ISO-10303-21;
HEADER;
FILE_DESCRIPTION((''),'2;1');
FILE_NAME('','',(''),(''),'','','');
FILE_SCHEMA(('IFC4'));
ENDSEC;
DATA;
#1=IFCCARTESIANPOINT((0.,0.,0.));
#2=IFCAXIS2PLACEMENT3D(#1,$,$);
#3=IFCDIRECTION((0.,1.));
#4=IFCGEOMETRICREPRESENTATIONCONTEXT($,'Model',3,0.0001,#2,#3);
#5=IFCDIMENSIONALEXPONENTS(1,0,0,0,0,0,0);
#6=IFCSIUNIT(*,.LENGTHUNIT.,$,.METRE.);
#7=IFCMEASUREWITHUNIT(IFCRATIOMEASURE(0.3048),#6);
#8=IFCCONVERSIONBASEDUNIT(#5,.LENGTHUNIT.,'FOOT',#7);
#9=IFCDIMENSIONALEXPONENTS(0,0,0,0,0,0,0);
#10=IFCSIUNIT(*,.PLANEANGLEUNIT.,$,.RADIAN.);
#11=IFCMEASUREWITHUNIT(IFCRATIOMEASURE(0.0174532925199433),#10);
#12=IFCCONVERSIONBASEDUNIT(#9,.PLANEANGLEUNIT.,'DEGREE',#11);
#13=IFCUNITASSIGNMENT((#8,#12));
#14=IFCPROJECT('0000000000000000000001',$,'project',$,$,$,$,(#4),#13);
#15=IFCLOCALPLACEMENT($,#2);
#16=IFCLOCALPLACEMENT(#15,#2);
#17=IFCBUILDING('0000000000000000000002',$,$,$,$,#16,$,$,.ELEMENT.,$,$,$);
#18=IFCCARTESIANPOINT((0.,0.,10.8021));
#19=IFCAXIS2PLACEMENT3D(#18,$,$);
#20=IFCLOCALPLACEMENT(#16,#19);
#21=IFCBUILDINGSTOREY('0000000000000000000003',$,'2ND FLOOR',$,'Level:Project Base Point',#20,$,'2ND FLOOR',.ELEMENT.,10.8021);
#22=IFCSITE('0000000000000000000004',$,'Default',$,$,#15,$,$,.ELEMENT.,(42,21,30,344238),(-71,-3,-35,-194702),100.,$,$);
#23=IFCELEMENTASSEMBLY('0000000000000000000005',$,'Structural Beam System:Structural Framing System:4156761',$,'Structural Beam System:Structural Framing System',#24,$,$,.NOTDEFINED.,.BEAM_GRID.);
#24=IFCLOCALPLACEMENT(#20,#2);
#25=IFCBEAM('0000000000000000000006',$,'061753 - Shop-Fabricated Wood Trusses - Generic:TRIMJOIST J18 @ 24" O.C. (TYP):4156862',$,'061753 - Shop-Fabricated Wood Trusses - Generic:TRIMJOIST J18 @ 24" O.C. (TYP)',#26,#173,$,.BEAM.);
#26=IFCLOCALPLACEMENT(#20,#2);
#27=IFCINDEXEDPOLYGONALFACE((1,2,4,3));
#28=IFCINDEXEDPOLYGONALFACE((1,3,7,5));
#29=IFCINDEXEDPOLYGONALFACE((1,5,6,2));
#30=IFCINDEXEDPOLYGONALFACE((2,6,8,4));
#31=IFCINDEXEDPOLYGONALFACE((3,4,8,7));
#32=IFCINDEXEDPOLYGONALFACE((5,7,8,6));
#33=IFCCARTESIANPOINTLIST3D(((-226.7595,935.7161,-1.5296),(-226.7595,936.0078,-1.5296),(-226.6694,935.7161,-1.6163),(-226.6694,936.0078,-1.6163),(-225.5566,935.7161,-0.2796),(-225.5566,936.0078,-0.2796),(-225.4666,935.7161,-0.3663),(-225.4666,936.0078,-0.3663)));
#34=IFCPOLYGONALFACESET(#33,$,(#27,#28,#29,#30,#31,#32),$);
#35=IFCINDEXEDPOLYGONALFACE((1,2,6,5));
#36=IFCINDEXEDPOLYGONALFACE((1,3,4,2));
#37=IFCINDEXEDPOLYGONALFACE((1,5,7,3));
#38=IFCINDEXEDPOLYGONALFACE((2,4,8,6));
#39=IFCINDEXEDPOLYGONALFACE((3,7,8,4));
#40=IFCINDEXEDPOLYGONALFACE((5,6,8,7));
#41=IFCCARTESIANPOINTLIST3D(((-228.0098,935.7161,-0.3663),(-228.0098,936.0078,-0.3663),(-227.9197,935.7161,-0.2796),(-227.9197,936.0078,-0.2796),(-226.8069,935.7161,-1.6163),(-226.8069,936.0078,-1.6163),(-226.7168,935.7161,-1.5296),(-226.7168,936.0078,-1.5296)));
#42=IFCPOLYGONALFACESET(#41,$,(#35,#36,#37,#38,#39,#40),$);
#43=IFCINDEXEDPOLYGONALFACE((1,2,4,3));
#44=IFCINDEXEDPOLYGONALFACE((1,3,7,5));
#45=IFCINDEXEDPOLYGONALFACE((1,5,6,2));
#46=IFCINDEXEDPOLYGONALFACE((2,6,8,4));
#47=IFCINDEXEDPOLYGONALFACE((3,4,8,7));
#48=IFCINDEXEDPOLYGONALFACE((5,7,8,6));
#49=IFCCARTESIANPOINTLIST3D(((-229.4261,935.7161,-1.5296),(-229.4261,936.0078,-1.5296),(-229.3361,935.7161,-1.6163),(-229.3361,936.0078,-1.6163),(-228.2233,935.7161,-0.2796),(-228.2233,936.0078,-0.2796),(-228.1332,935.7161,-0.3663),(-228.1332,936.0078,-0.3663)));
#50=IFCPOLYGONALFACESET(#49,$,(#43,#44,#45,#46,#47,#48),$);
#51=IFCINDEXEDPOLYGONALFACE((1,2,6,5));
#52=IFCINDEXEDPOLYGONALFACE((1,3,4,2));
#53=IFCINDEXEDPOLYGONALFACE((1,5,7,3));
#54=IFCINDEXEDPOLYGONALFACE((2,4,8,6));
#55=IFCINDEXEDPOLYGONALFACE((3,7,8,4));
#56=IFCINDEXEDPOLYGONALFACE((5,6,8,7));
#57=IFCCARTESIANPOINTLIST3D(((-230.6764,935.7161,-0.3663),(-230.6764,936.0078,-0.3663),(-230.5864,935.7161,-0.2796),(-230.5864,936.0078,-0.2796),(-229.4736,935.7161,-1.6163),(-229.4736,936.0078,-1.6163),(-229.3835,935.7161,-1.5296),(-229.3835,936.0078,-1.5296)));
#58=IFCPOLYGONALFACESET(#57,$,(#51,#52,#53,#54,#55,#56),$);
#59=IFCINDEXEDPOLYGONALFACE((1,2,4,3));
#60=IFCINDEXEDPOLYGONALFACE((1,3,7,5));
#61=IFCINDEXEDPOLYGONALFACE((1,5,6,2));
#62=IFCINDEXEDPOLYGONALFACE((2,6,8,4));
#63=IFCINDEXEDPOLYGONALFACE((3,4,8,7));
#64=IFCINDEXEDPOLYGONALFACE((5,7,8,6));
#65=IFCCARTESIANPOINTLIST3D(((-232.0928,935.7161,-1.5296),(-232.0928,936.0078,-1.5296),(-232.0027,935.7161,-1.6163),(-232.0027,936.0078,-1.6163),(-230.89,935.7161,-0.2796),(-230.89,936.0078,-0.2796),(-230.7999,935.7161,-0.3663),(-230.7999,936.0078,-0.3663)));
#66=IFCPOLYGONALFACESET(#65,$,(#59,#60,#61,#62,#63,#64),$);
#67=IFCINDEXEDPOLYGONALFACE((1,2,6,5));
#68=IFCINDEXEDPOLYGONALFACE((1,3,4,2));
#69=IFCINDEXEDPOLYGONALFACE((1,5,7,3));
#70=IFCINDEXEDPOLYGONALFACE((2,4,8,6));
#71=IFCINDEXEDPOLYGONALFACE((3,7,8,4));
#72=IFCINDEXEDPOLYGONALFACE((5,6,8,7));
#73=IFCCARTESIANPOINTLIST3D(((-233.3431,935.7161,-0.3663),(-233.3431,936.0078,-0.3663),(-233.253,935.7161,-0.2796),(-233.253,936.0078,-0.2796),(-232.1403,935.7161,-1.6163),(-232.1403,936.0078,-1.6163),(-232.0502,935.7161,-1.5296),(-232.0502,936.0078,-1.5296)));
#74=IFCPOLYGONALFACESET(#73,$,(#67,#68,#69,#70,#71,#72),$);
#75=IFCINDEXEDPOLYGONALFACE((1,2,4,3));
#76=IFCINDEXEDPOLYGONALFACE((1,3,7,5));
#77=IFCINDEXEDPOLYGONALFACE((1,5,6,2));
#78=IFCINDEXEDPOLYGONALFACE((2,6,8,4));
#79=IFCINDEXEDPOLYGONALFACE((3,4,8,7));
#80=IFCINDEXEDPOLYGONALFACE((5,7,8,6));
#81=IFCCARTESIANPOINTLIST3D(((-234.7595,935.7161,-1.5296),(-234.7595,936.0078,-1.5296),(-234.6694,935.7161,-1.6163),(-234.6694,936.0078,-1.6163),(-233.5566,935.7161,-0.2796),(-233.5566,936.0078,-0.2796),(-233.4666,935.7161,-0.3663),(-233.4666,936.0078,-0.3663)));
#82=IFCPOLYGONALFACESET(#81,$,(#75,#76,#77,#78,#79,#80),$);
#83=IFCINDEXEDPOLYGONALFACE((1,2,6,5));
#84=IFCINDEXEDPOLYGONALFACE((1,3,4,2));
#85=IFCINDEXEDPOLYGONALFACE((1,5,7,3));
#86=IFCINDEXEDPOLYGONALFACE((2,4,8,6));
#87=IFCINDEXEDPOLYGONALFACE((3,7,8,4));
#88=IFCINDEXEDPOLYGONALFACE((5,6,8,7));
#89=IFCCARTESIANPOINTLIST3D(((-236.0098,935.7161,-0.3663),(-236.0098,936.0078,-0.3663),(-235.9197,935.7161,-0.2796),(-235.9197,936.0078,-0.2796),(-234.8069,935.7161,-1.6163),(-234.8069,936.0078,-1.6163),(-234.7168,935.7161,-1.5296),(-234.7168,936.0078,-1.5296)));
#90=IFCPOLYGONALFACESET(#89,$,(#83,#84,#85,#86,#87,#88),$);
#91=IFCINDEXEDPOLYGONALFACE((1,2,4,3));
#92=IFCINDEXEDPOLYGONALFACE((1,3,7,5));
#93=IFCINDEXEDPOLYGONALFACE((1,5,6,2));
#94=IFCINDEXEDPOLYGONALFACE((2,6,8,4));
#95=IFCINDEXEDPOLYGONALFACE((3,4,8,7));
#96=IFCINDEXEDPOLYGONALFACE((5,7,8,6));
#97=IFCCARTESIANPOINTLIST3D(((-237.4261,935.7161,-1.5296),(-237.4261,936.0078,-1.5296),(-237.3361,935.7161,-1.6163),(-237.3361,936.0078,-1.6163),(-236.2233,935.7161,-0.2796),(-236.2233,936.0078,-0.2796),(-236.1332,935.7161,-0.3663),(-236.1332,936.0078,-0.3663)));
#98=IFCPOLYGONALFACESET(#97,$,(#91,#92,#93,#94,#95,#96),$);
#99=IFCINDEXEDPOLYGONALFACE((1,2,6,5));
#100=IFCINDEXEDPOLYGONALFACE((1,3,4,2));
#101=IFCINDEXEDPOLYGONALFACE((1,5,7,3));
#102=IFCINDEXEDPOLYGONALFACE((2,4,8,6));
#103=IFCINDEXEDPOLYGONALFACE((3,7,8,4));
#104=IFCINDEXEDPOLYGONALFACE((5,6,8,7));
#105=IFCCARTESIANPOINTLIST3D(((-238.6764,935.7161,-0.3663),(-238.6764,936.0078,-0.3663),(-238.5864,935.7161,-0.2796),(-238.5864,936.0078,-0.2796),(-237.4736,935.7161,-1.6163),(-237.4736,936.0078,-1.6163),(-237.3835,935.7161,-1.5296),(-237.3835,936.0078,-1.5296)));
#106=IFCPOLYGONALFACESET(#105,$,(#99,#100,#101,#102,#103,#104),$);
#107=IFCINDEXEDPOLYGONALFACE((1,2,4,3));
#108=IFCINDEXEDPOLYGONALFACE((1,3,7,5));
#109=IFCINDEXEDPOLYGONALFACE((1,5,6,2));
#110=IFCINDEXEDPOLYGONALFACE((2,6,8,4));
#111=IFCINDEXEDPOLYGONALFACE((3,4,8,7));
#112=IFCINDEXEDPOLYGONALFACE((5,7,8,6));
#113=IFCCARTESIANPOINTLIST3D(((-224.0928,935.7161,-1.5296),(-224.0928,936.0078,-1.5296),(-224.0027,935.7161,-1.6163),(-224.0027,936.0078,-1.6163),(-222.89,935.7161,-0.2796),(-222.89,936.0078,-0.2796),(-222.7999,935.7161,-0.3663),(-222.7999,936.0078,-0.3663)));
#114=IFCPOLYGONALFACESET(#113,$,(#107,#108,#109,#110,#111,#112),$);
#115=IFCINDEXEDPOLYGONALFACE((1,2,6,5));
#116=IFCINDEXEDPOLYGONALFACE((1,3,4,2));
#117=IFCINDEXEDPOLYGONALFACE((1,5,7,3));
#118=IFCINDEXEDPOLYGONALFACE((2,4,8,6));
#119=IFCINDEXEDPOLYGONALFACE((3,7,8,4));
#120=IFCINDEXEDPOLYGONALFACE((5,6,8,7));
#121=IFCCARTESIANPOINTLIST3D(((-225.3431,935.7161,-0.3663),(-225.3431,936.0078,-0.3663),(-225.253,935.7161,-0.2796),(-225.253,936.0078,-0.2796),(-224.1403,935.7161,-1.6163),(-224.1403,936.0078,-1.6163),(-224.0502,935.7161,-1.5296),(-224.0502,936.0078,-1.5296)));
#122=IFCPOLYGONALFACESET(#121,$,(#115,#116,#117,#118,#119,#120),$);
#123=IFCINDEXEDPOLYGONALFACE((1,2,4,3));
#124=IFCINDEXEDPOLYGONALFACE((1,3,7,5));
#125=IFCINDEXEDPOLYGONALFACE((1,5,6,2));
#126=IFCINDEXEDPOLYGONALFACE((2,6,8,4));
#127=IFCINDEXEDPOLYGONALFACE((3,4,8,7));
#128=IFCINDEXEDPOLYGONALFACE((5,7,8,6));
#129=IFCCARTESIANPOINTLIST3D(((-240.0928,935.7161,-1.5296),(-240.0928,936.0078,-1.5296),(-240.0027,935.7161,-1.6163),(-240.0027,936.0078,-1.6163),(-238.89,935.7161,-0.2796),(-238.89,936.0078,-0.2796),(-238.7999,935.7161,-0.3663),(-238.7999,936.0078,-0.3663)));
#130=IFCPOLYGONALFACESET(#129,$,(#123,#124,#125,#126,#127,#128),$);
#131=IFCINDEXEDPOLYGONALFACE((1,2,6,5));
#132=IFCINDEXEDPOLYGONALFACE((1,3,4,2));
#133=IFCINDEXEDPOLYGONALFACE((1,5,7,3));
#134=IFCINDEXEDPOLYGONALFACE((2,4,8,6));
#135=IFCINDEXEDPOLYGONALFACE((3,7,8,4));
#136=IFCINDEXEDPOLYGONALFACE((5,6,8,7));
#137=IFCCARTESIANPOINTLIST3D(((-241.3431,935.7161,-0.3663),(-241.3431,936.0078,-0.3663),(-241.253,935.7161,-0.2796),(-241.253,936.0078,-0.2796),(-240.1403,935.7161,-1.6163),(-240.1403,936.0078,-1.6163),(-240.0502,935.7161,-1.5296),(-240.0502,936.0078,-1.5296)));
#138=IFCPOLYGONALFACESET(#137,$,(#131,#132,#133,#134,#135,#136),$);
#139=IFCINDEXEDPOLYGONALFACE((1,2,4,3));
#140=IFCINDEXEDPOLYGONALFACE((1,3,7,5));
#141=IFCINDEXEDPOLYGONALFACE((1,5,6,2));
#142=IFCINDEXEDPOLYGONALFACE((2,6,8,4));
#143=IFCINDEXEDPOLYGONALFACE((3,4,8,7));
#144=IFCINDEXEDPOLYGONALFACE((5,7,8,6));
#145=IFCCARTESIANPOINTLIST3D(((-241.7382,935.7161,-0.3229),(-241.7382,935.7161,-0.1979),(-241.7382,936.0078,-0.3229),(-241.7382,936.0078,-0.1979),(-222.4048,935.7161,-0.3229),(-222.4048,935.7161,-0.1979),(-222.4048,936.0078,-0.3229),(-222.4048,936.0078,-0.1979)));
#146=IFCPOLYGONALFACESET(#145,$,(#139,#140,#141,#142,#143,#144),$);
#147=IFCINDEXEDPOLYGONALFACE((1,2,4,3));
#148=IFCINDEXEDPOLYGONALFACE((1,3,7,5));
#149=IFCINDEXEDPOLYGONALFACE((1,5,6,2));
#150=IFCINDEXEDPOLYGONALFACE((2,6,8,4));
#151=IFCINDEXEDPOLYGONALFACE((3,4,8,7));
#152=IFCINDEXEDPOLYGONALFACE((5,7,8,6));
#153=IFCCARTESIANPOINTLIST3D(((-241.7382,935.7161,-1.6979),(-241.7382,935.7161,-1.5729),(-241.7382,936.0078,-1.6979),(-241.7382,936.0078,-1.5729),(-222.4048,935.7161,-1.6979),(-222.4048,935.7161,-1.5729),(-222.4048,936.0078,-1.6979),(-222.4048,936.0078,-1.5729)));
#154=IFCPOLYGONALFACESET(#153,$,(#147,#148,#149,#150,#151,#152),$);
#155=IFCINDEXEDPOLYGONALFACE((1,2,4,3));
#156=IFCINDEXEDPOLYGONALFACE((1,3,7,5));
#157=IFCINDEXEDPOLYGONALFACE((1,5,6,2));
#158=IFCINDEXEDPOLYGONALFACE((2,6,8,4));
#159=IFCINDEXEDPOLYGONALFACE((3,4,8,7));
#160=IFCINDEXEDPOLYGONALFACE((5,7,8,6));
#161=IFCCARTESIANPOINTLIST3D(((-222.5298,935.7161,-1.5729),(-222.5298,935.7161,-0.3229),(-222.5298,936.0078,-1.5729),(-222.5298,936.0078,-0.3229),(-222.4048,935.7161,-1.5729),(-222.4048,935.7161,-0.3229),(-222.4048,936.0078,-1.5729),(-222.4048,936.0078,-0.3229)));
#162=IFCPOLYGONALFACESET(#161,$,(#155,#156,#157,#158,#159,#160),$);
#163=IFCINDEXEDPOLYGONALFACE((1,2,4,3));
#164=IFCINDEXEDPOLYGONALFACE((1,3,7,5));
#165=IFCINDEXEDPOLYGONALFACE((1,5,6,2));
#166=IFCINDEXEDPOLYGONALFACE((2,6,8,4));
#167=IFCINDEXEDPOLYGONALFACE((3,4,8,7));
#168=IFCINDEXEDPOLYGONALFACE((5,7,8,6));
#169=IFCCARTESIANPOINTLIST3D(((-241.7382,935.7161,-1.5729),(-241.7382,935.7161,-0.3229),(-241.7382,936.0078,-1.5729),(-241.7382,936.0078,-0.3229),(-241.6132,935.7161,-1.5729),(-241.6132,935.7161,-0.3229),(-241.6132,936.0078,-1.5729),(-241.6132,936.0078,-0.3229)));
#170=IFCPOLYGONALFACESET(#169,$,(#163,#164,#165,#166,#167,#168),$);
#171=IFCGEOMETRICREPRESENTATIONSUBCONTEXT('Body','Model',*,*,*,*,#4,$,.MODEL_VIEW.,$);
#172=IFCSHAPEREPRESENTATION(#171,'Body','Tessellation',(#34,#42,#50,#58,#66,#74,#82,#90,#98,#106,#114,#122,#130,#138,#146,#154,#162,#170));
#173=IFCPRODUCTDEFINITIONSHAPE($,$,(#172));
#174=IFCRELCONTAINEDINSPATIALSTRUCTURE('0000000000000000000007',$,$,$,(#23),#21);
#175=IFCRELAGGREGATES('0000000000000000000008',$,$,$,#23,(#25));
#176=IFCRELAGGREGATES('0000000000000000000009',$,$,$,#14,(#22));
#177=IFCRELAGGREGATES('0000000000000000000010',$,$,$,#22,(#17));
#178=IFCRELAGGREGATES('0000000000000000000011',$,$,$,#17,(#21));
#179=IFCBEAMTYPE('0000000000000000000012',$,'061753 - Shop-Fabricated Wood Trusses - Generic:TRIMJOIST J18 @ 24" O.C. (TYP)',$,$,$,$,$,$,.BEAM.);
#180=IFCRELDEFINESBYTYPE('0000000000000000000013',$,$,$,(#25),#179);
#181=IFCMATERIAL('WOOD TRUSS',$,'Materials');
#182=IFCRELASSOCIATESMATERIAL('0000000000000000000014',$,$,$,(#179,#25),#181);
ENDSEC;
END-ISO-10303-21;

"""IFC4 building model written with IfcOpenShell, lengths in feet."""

from ifc_helpers import new_model, entity, si_unit, converted_unit, direction, frame, frame_2d, origin, origin_2d_with_axis, place, context, subcontext, project, spatial, rectangle, extrude, source, transform, mapped, material, material_profile, profile_set, profile_usage, type_object, type_shapes, element, aggregate, save


model = new_model("IFC4")

# Units and contexts
model_context = context("Model", 3, precision=0.0001, world=origin(), true_north=direction((0.0, 1.0)))
body_context = subcontext(model_context, "Body", "Model", "MODEL_VIEW")
ifc_project = project(units=[converted_unit("LENGTHUNIT", "FOOT", entity("IfcRatioMeasure", 0.3048), si_unit("LENGTHUNIT", "METRE"), dimensions=[1, 0, 0, 0, 0, 0, 0]), converted_unit("PLANEANGLEUNIT", "DEGREE", entity("IfcRatioMeasure", 0.0174532925199433), si_unit("PLANEANGLEUNIT", "RADIAN"), dimensions=[0, 0, 0, 0, 0, 0, 0])], contexts=[model_context])

# Site, building, storey
site_placement = place(None, origin())
site = spatial("IfcSite", under=ifc_project, at=site_placement, Name="Default", CompositionType="ELEMENT", RefLatitude=(42, 21, 30, 344238), RefLongitude=(-71, -3, -35, -194702), RefElevation=100.0)
building_placement = place(site_placement, origin())
building = spatial("IfcBuilding", under=site, at=building_placement, CompositionType="ELEMENT")
storey_placement = place(building_placement, frame((0.0, 0.0, 10.8021)))
storey = spatial("IfcBuildingStorey", under=building, at=storey_placement, Name="2ND FLOOR", ObjectType="Level:Project Base Point", LongName="2ND FLOOR", CompositionType="ELEMENT", Elevation=10.8021)

# Element assembly, beam
ifc_material_1 = material(Name="WOOD TRUSS", Category="Materials")
ifc_material_profile_1 = material_profile(ifc_material_1, rectangle(XDim=1.7347, YDim=0.125, at=frame_2d((0.0, 0.0), x_axis=(1.0, 0.0))), Name="TRIMJOIST J18 @ 24\" O.C. (TYP)")
ifc_material_profile_2 = material_profile(ifc_material_1, rectangle(XDim=1.7347, YDim=0.125, at=frame_2d((0.0, 0.0), x_axis=(1.0, 0.0))), Name="TRIMJOIST J18 @ 24\" O.C. (TYP)")
ifc_material_profile_3 = material_profile(ifc_material_1, rectangle(XDim=1.7347, YDim=0.125, at=frame_2d((0.0, 0.0), x_axis=(1.0, 0.0))), Name="TRIMJOIST J18 @ 24\" O.C. (TYP)")
ifc_material_profile_4 = material_profile(ifc_material_1, rectangle(XDim=1.7347, YDim=0.125, at=frame_2d((0.0, 0.0), x_axis=(1.0, 0.0))), Name="TRIMJOIST J18 @ 24\" O.C. (TYP)")
ifc_material_profile_5 = material_profile(ifc_material_1, rectangle(XDim=1.7347, YDim=0.125, at=frame_2d((0.0, 0.0), x_axis=(1.0, 0.0))), Name="TRIMJOIST J18 @ 24\" O.C. (TYP)")
ifc_material_profile_6 = material_profile(ifc_material_1, rectangle(XDim=1.7347, YDim=0.125, at=frame_2d((0.0, 0.0), x_axis=(1.0, 0.0))), Name="TRIMJOIST J18 @ 24\" O.C. (TYP)")
ifc_material_profile_7 = material_profile(ifc_material_1, rectangle(XDim=1.7347, YDim=0.125, at=frame_2d((0.0, 0.0), x_axis=(1.0, 0.0))), Name="TRIMJOIST J18 @ 24\" O.C. (TYP)")
ifc_material_profile_8 = material_profile(ifc_material_1, rectangle(XDim=1.7347, YDim=0.125, at=frame_2d((0.0, 0.0), x_axis=(1.0, 0.0))), Name="TRIMJOIST J18 @ 24\" O.C. (TYP)")
ifc_material_profile_9 = material_profile(ifc_material_1, rectangle(XDim=1.7347, YDim=0.125, at=frame_2d((0.0, 0.0), x_axis=(1.0, 0.0))), Name="TRIMJOIST J18 @ 24\" O.C. (TYP)")
ifc_material_profile_10 = material_profile(ifc_material_1, rectangle(XDim=1.7347, YDim=0.125, at=origin_2d_with_axis()), Name="TRIMJOIST J18 @ 24\" O.C. (TYP)")
ifc_material_profile_11 = material_profile(ifc_material_1, rectangle(XDim=0.125, YDim=0.2917, at=origin_2d_with_axis()), Name="TRIMJOIST J18 @ 24\" O.C. (TYP)")
ifc_material_profile_12 = material_profile(ifc_material_1, rectangle(XDim=0.125, YDim=0.2917, at=origin_2d_with_axis()), Name="TRIMJOIST J18 @ 24\" O.C. (TYP)")
ifc_material_profile_13 = material_profile(ifc_material_1, rectangle(XDim=1.25, YDim=0.2917, at=origin_2d_with_axis()), Name="TRIMJOIST J18 @ 24\" O.C. (TYP)")
ifc_material_profile_14 = material_profile(ifc_material_1, rectangle(XDim=1.25, YDim=0.2917, at=origin_2d_with_axis()), Name="TRIMJOIST J18 @ 24\" O.C. (TYP)")
ifc_profile_set_1 = profile_set([ifc_material_profile_1, ifc_material_profile_2, ifc_material_profile_3, ifc_material_profile_4, ifc_material_profile_5, ifc_material_profile_6, ifc_material_profile_7, ifc_material_profile_8, ifc_material_profile_9, ifc_material_profile_10, ifc_material_profile_11, ifc_material_profile_12, ifc_material_profile_13, ifc_material_profile_14], Name="TRIMJOIST J18 @ 24\" O.C. (TYP)")
assembly_1_placement = place(storey_placement, origin())
assembly_1 = element("IfcElementAssembly", 1, at=assembly_1_placement, inside=storey, Name="Structural Beam System:Structural Framing System:4156761", ObjectType="Structural Beam System:Structural Framing System", AssemblyPlace="NOTDEFINED", PredefinedType="BEAM_GRID")
beam_type_1 = type_object("IfcBeamType", Name="061753 - Shop-Fabricated Wood Trusses - Generic:TRIMJOIST J18 @ 24\" O.C. (TYP)", PredefinedType="BEAM", material=ifc_profile_set_1)
shared_shape_1 = source(origin(), body_context, "Body", "SweptSolid", [
    extrude(rectangle(XDim=1.7347, YDim=0.125, at=frame_2d((0.0, 0.0), x_axis=(1.0, 0.0))), frame((5.9585, -0.1458, 0.0), z_axis=(0.0, 1.0, 0.0), x_axis=(0.693383, 0.0, 0.720569)), (0.0, 0.0, 1.0), 0.2917),
    extrude(rectangle(XDim=1.7347, YDim=0.125, at=origin_2d_with_axis()), frame((4.7082, -0.1458, 0.0), z_axis=(0.0, 1.0, 0.0), x_axis=(0.693383, 0.0, -0.720569)), (0.0, 0.0, 1.0), 0.2917),
    extrude(rectangle(XDim=1.7347, YDim=0.125, at=frame_2d((0.0, 0.0), x_axis=(1.0, 0.0))), frame((3.2918, -0.1458, 0.0), z_axis=(0.0, 1.0, 0.0), x_axis=(0.693383, 0.0, 0.720569)), (0.0, 0.0, 1.0), 0.2917),
    extrude(rectangle(XDim=1.7347, YDim=0.125, at=frame_2d((0.0, 0.0), x_axis=(1.0, 0.0))), frame((2.0415, -0.1458, 0.0), z_axis=(0.0, 1.0, 0.0), x_axis=(0.693383, 0.0, -0.720569)), (0.0, 0.0, 1.0), 0.2917),
    extrude(rectangle(XDim=1.7347, YDim=0.125, at=frame_2d((0.0, 0.0), x_axis=(1.0, 0.0))), frame((0.6251, -0.1458, 0.0), z_axis=(0.0, 1.0, 0.0), x_axis=(0.693383, 0.0, 0.720569)), (0.0, 0.0, 1.0), 0.2917),
    extrude(rectangle(XDim=1.7347, YDim=0.125, at=frame_2d((0.0, 0.0), x_axis=(1.0, 0.0))), frame((-0.6251, -0.1458, 0.0), z_axis=(0.0, 1.0, 0.0), x_axis=(0.693383, 0.0, -0.720569)), (0.0, 0.0, 1.0), 0.2917),
    extrude(rectangle(XDim=1.7347, YDim=0.125, at=frame_2d((0.0, 0.0), x_axis=(1.0, 0.0))), frame((-2.0415, -0.1458, 0.0), z_axis=(0.0, 1.0, 0.0), x_axis=(0.693383, 0.0, 0.720569)), (0.0, 0.0, 1.0), 0.2917),
    extrude(rectangle(XDim=1.7347, YDim=0.125, at=origin_2d_with_axis()), frame((-3.2918, -0.1458, 0.0), z_axis=(0.0, 1.0, 0.0), x_axis=(0.693383, 0.0, -0.720569)), (0.0, 0.0, 1.0), 0.2917),
    extrude(rectangle(XDim=1.7347, YDim=0.125, at=frame_2d((0.0, 0.0), x_axis=(1.0, 0.0))), frame((-4.7082, -0.1458, 0.0), z_axis=(0.0, 1.0, 0.0), x_axis=(0.693383, 0.0, 0.720569)), (0.0, 0.0, 1.0), 0.2917),
    extrude(rectangle(XDim=1.7347, YDim=0.125, at=frame_2d((0.0, 0.0), x_axis=(1.0, 0.0))), frame((-5.9585, -0.1458, 0.0), z_axis=(0.0, 1.0, 0.0), x_axis=(0.693383, 0.0, -0.720569)), (0.0, 0.0, 1.0), 0.2917),
    extrude(rectangle(XDim=1.7347, YDim=0.125, at=frame_2d((0.0, 0.0), x_axis=(1.0, 0.0))), frame((8.6251, -0.1458, 0.0), z_axis=(0.0, 1.0, 0.0), x_axis=(0.693383, 0.0, 0.720569)), (0.0, 0.0, 1.0), 0.2917),
    extrude(rectangle(XDim=1.7347, YDim=0.125, at=origin_2d_with_axis()), frame((7.3749, -0.1458, 0.0), z_axis=(0.0, 1.0, 0.0), x_axis=(0.693383, 0.0, -0.720569)), (0.0, 0.0, 1.0), 0.2917),
    extrude(rectangle(XDim=1.7347, YDim=0.125, at=frame_2d((0.0, 0.0), x_axis=(1.0, 0.0))), frame((-7.3749, -0.1458, 0.0), z_axis=(0.0, 1.0, 0.0), x_axis=(0.693383, 0.0, 0.720569)), (0.0, 0.0, 1.0), 0.2917),
    extrude(rectangle(XDim=1.7347, YDim=0.125, at=origin_2d_with_axis()), frame((-8.6251, -0.1458, 0.0), z_axis=(0.0, 1.0, 0.0), x_axis=(0.693383, 0.0, -0.720569)), (0.0, 0.0, 1.0), 0.2917),
    extrude(rectangle(XDim=0.125, YDim=0.2917, at=origin_2d_with_axis()), frame((-9.6667, 0.0, 0.6875), z_axis=(1.0, 0.0, 0.0), x_axis=(0.0, 0.0, -1.0)), (0.0, 0.0, 1.0), 19.3333),
    extrude(rectangle(XDim=0.125, YDim=0.2917, at=origin_2d_with_axis()), frame((-9.6667, 0.0, -0.6875), z_axis=(1.0, 0.0, 0.0), x_axis=(0.0, 0.0, -1.0)), (0.0, 0.0, 1.0), 19.3333),
    extrude(rectangle(XDim=1.25, YDim=0.2917, at=origin_2d_with_axis()), frame((9.5417, 0.0, 0.0), z_axis=(1.0, 0.0, 0.0), x_axis=(0.0, 0.0, -1.0)), (0.0, 0.0, 1.0), 0.125),
    extrude(rectangle(XDim=1.25, YDim=0.2917, at=origin_2d_with_axis()), frame((-9.6667, 0.0, 0.0), z_axis=(1.0, 0.0, 0.0), x_axis=(0.0, 0.0, -1.0)), (0.0, 0.0, 1.0), 0.125),
])
type_shapes(beam_type_1, [shared_shape_1])
ifc_profile_usage_1 = profile_usage(ifc_profile_set_1, cardinal=8)
beam_1_placement = place(assembly_1_placement, frame((-232.0715, 935.8619, -0.9479)))
beam_1 = element("IfcBeam", 2, at=beam_1_placement, type_object=beam_type_1, material=ifc_profile_usage_1, Name="061753 - Shop-Fabricated Wood Trusses - Generic:TRIMJOIST J18 @ 24\" O.C. (TYP):4156862", ObjectType="061753 - Shop-Fabricated Wood Trusses - Generic:TRIMJOIST J18 @ 24\" O.C. (TYP)", PredefinedType="BEAM", context=body_context, shape_type="MappedRepresentation", body=[
    mapped(shared_shape_1, transform((0.0, 0.0, 0.0), scale=1.0)),
])
aggregate(assembly_1, [beam_1])

save(model, "model.ifc")
